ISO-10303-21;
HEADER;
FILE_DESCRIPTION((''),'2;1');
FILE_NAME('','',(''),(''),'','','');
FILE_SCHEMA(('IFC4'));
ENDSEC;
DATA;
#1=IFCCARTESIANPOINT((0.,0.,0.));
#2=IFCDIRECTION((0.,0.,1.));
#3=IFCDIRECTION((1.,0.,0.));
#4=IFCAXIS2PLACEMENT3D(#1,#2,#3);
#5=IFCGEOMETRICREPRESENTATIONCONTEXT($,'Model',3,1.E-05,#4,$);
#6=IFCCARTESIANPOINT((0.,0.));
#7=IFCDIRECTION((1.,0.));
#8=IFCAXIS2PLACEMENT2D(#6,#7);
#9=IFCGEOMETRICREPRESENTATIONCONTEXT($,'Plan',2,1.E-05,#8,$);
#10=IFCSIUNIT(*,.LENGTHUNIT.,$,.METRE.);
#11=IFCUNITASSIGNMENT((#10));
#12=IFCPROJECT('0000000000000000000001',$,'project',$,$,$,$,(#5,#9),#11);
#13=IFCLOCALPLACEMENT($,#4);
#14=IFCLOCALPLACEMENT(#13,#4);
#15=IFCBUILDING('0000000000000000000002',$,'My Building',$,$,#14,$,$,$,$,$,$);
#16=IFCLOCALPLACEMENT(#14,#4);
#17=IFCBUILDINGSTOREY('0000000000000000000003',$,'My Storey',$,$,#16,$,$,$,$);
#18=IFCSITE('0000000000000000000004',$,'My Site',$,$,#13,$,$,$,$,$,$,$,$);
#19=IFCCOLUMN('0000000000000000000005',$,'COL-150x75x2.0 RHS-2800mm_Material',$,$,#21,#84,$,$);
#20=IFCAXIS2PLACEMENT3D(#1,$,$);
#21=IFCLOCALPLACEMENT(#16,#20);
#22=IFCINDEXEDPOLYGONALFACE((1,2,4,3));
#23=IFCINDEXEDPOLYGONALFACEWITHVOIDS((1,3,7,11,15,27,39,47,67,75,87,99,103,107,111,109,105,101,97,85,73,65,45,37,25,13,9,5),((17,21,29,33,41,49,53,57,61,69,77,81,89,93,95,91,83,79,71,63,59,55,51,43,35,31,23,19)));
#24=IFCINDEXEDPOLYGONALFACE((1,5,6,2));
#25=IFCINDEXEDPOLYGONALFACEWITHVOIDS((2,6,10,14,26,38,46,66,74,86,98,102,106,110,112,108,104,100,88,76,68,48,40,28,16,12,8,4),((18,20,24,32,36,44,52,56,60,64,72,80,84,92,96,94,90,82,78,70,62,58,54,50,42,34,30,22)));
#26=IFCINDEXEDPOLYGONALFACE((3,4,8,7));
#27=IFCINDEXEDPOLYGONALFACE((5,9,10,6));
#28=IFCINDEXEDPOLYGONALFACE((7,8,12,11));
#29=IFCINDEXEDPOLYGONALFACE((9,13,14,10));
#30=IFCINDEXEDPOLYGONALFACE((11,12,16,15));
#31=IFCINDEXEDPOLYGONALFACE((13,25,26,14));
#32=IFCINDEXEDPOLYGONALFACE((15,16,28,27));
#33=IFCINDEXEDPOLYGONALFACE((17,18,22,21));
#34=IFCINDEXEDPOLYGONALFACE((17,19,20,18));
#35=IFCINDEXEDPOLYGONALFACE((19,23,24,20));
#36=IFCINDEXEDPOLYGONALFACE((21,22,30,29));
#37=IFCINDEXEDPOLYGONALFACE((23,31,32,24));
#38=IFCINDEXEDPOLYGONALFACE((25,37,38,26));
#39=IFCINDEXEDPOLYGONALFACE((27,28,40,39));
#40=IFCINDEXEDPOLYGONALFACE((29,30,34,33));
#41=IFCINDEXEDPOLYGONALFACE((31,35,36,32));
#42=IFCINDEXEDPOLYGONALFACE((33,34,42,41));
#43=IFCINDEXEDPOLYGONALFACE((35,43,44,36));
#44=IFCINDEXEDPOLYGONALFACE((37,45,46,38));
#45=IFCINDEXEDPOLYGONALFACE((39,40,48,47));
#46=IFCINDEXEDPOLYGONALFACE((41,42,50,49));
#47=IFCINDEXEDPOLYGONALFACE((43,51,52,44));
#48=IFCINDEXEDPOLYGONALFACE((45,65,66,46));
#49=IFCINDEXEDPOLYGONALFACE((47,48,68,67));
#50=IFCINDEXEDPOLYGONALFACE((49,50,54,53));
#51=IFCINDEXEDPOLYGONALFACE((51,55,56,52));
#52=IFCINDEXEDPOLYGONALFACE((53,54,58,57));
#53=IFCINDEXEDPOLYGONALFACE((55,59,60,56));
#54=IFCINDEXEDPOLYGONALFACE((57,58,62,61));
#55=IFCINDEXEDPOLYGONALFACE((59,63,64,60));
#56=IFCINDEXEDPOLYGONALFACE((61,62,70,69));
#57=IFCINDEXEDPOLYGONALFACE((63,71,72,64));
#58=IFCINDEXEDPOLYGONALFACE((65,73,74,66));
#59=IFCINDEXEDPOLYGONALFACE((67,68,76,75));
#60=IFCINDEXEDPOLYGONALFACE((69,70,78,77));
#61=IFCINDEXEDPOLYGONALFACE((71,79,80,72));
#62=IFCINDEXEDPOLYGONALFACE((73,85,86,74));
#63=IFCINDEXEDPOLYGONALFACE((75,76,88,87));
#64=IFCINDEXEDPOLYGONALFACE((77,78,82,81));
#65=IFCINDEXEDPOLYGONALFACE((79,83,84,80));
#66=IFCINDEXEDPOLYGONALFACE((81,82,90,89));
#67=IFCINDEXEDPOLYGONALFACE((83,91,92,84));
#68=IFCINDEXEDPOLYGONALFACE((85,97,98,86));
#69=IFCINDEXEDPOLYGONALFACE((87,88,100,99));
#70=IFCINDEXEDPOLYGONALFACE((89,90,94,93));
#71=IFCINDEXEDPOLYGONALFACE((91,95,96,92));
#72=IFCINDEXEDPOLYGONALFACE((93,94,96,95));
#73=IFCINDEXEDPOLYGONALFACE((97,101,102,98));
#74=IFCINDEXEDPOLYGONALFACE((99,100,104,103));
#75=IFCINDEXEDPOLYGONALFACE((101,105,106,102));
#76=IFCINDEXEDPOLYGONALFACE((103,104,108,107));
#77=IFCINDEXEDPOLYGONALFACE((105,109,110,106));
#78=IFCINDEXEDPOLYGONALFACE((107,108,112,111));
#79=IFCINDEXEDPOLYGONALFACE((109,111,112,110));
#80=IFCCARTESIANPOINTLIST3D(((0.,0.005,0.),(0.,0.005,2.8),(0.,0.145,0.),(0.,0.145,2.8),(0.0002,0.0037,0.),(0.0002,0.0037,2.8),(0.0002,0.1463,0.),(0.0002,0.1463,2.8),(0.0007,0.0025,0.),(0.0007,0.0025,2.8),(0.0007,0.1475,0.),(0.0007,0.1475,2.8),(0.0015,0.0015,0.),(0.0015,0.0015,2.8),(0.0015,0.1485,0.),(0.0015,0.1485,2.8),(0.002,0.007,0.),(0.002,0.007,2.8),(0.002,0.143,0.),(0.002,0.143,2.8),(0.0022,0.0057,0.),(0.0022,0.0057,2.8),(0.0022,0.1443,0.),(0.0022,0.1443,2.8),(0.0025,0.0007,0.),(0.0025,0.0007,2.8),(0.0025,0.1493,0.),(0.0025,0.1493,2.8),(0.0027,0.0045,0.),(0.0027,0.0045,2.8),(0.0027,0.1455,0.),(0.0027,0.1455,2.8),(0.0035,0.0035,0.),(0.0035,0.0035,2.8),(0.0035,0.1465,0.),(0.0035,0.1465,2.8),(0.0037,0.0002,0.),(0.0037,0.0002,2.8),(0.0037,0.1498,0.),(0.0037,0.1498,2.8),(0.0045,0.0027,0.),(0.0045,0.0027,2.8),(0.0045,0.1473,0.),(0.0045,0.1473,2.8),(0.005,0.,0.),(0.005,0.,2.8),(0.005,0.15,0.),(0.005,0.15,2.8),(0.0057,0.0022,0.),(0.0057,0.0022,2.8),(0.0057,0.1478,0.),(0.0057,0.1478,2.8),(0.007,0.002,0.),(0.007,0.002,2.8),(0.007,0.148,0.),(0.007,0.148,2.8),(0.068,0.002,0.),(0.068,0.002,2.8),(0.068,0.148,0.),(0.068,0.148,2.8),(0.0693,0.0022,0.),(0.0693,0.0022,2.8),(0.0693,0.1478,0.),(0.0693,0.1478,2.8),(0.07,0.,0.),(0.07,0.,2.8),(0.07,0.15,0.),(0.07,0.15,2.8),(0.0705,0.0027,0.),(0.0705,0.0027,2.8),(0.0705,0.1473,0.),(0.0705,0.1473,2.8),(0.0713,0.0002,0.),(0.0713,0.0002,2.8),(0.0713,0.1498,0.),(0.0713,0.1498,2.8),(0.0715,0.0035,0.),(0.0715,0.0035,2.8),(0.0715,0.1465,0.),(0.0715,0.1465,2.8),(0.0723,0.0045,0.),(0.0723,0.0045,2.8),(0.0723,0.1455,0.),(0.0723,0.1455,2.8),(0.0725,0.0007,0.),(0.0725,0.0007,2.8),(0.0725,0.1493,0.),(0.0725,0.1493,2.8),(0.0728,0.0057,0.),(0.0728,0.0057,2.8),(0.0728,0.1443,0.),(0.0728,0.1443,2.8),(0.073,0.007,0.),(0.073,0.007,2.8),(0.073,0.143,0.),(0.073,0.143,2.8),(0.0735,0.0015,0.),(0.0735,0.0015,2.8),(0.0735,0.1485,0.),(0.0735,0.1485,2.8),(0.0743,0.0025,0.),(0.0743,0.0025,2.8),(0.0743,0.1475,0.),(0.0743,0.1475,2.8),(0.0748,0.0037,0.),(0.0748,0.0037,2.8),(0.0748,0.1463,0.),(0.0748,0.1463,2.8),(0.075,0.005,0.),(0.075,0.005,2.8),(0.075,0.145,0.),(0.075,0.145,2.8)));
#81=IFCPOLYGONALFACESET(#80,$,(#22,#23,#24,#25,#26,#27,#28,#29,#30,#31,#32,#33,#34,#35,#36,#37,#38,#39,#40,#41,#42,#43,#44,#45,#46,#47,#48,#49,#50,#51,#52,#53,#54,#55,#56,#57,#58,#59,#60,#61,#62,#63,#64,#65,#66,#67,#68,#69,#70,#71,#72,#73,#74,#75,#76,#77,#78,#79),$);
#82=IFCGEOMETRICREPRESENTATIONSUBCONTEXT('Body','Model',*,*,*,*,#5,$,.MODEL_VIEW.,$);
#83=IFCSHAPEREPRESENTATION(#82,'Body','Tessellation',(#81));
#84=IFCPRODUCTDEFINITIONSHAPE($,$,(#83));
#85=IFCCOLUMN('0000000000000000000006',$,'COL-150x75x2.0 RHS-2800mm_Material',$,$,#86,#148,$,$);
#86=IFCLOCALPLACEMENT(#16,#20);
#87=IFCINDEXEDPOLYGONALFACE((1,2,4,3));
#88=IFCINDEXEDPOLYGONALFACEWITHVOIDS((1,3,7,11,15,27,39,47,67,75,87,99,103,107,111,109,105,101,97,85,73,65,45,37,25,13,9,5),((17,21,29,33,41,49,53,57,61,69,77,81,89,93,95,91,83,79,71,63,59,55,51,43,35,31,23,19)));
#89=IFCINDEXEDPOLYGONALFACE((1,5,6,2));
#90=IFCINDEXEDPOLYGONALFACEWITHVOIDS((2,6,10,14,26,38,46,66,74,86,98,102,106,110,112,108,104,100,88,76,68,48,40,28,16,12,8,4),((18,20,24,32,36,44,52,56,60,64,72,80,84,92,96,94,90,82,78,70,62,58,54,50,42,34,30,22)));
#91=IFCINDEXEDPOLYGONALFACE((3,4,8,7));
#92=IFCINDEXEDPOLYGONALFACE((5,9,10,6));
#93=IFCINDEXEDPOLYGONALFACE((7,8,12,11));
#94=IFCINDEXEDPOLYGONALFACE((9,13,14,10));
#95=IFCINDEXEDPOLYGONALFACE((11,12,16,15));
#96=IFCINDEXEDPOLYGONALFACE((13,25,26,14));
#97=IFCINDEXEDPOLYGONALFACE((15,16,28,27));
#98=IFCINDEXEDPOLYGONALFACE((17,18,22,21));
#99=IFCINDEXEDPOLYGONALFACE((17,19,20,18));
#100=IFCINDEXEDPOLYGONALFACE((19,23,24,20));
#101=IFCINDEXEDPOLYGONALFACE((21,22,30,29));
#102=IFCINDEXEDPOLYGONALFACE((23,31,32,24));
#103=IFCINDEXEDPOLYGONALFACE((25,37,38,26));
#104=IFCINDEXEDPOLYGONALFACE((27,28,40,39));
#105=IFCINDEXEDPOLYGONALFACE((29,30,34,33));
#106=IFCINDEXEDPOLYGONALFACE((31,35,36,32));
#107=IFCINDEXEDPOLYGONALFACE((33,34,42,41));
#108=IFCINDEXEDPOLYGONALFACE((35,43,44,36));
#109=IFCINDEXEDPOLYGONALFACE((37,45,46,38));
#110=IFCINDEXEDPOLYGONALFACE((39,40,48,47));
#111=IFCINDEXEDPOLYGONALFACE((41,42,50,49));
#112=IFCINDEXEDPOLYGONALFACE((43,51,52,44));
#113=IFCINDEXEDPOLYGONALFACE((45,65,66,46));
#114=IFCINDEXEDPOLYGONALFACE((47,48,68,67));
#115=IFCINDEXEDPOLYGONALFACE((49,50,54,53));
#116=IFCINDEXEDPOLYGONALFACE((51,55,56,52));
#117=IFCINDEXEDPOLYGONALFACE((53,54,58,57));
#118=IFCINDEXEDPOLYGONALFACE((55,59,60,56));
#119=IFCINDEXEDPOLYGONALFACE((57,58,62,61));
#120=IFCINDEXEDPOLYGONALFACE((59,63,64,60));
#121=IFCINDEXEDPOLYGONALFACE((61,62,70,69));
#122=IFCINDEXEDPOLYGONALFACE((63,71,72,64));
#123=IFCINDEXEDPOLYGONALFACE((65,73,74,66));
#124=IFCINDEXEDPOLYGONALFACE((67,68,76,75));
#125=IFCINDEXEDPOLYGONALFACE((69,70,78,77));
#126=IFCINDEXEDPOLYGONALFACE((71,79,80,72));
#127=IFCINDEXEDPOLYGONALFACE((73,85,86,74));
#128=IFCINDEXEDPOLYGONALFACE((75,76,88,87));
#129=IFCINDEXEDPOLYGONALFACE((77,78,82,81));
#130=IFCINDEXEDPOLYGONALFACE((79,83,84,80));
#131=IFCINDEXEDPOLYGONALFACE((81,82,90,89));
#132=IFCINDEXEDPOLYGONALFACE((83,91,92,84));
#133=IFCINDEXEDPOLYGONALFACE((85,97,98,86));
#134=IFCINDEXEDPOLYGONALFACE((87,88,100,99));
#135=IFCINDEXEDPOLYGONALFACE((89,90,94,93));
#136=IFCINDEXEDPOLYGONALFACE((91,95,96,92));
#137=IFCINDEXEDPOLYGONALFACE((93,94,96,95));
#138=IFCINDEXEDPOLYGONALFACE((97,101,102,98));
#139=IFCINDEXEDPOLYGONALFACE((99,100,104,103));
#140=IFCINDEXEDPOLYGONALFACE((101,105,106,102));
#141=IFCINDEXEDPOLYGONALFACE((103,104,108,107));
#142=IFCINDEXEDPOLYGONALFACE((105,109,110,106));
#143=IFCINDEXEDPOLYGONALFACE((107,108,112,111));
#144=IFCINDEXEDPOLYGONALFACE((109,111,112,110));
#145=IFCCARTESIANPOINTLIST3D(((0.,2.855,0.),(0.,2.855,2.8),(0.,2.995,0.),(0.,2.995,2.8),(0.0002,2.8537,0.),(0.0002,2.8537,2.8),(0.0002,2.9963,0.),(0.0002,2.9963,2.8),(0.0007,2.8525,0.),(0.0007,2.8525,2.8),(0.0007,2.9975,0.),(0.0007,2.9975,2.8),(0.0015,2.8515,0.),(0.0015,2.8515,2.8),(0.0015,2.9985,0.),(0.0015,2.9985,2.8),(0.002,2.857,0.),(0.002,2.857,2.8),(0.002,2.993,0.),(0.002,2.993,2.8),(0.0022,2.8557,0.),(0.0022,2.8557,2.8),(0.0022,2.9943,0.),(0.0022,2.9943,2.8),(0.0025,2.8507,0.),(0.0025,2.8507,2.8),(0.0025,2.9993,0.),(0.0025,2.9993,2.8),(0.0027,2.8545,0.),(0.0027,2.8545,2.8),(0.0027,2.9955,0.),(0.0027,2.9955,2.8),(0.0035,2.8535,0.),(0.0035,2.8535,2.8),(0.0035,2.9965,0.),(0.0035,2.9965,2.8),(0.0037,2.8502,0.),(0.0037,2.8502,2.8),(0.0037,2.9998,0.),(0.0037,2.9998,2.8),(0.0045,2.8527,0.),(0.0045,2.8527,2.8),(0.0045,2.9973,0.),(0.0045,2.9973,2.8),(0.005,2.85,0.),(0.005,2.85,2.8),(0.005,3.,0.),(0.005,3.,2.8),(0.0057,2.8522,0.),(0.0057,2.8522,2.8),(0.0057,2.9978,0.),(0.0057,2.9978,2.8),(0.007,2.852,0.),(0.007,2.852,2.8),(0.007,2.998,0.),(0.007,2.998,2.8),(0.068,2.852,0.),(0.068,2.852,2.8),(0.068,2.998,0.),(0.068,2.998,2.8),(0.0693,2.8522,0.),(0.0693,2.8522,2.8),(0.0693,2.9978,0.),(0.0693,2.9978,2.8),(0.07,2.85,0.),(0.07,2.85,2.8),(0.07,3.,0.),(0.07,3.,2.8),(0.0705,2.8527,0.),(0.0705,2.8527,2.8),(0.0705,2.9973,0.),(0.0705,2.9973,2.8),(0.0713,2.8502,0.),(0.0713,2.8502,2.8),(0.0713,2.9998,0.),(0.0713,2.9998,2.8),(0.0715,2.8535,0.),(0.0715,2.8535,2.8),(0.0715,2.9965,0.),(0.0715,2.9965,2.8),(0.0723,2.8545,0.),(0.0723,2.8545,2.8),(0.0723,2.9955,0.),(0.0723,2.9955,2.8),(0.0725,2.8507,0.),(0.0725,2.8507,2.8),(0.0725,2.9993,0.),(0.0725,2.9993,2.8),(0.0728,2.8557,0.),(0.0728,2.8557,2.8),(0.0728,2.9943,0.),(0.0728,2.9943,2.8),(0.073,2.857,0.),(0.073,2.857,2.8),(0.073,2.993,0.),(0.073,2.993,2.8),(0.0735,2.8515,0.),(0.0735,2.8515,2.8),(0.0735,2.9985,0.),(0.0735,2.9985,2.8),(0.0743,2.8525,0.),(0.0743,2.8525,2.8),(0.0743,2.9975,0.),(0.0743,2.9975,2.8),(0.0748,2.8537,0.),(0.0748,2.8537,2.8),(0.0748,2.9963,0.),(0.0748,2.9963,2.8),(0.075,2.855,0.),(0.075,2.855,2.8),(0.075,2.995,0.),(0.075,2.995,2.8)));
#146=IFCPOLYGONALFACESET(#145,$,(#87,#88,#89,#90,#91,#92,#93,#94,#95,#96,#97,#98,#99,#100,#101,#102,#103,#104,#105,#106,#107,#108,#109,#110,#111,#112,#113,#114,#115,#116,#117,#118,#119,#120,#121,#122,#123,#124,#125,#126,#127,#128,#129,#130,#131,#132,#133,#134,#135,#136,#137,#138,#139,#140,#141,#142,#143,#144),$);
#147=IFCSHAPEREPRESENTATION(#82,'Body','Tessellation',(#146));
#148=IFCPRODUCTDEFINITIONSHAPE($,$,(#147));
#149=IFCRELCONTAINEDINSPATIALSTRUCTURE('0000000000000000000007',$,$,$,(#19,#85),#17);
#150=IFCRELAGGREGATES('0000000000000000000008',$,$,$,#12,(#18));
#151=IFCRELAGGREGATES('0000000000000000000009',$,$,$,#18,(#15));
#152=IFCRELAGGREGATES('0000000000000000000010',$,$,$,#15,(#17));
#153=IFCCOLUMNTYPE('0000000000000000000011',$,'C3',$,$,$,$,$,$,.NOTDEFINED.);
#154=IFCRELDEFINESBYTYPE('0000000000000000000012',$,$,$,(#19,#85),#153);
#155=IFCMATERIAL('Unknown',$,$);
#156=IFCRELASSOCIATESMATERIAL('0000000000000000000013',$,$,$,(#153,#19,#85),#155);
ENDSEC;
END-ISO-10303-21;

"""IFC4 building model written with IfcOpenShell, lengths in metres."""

from ifc_helpers import new_model, si_unit, frame, origin_with_axes, origin_2d_with_axis, place, context, subcontext, project, spatial, hollow_rectangle, extrude, material, material_profile, profile_set, profile_usage, type_object, element, save


model = new_model("IFC4")

# Units and contexts
model_context = context("Model", 3, precision=1e-05, world=origin_with_axes())
plan_context = context("Plan", 2, precision=1e-05, world=origin_2d_with_axis())
body_context = subcontext(model_context, "Body", "Model", "MODEL_VIEW")
ifc_project = project(units=[si_unit("LENGTHUNIT", "METRE")], contexts=[model_context, plan_context])

# Site, building, storey
site_placement = place(None, origin_with_axes())
site = spatial("IfcSite", under=ifc_project, at=site_placement, Name="My Site")
building_placement = place(site_placement, origin_with_axes())
building = spatial("IfcBuilding", under=site, at=building_placement, Name="My Building")
storey_placement = place(building_placement, origin_with_axes())
storey = spatial("IfcBuildingStorey", under=building, at=storey_placement, Name="My Storey")

# Columns
ifc_material_1 = material(Name="Unknown")
ifc_material_profile_1 = material_profile(ifc_material_1, hollow_rectangle(XDim=0.075, YDim=0.15, WallThickness=0.002, InnerFilletRadius=0.005, OuterFilletRadius=0.005))
ifc_profile_set_1 = profile_set([ifc_material_profile_1])
ifc_profile_usage_1 = profile_usage(ifc_profile_set_1, cardinal=1)
column_type = type_object("IfcColumnType", Name="C3", PredefinedType="NOTDEFINED", material=ifc_profile_set_1)
column_1_placement = place(storey_placement, origin_with_axes())
element("IfcColumn", 1, at=column_1_placement, inside=storey, type_object=column_type, material=ifc_profile_usage_1, Name="COL-150x75x2.0 RHS-2800mm_Material", context=body_context, shape_type="SweptSolid", body=[
    extrude(hollow_rectangle(XDim=0.075, YDim=0.15, WallThickness=0.002, InnerFilletRadius=0.005, OuterFilletRadius=0.005), frame((0.0375, 0.075, 0.0)), (0.0, 0.0, 1.0), 2.8),
])
ifc_profile_usage_2 = profile_usage(ifc_profile_set_1, cardinal=7)
column_2_placement = place(storey_placement, frame((0.0, 3.0, 0.0), z_axis=(0.0, 0.0, 1.0), x_axis=(1.0, 0.0, 0.0)))
element("IfcColumn", 2, at=column_2_placement, inside=storey, type_object=column_type, material=ifc_profile_usage_2, Name="COL-150x75x2.0 RHS-2800mm_Material", context=body_context, shape_type="SweptSolid", body=[
    extrude(hollow_rectangle(XDim=0.075, YDim=0.15, WallThickness=0.002, InnerFilletRadius=0.005, OuterFilletRadius=0.005), frame((0.0375, -0.075, 0.0)), (0.0, 0.0, 1.0), 2.8),
])

save(model, "model.ifc")
